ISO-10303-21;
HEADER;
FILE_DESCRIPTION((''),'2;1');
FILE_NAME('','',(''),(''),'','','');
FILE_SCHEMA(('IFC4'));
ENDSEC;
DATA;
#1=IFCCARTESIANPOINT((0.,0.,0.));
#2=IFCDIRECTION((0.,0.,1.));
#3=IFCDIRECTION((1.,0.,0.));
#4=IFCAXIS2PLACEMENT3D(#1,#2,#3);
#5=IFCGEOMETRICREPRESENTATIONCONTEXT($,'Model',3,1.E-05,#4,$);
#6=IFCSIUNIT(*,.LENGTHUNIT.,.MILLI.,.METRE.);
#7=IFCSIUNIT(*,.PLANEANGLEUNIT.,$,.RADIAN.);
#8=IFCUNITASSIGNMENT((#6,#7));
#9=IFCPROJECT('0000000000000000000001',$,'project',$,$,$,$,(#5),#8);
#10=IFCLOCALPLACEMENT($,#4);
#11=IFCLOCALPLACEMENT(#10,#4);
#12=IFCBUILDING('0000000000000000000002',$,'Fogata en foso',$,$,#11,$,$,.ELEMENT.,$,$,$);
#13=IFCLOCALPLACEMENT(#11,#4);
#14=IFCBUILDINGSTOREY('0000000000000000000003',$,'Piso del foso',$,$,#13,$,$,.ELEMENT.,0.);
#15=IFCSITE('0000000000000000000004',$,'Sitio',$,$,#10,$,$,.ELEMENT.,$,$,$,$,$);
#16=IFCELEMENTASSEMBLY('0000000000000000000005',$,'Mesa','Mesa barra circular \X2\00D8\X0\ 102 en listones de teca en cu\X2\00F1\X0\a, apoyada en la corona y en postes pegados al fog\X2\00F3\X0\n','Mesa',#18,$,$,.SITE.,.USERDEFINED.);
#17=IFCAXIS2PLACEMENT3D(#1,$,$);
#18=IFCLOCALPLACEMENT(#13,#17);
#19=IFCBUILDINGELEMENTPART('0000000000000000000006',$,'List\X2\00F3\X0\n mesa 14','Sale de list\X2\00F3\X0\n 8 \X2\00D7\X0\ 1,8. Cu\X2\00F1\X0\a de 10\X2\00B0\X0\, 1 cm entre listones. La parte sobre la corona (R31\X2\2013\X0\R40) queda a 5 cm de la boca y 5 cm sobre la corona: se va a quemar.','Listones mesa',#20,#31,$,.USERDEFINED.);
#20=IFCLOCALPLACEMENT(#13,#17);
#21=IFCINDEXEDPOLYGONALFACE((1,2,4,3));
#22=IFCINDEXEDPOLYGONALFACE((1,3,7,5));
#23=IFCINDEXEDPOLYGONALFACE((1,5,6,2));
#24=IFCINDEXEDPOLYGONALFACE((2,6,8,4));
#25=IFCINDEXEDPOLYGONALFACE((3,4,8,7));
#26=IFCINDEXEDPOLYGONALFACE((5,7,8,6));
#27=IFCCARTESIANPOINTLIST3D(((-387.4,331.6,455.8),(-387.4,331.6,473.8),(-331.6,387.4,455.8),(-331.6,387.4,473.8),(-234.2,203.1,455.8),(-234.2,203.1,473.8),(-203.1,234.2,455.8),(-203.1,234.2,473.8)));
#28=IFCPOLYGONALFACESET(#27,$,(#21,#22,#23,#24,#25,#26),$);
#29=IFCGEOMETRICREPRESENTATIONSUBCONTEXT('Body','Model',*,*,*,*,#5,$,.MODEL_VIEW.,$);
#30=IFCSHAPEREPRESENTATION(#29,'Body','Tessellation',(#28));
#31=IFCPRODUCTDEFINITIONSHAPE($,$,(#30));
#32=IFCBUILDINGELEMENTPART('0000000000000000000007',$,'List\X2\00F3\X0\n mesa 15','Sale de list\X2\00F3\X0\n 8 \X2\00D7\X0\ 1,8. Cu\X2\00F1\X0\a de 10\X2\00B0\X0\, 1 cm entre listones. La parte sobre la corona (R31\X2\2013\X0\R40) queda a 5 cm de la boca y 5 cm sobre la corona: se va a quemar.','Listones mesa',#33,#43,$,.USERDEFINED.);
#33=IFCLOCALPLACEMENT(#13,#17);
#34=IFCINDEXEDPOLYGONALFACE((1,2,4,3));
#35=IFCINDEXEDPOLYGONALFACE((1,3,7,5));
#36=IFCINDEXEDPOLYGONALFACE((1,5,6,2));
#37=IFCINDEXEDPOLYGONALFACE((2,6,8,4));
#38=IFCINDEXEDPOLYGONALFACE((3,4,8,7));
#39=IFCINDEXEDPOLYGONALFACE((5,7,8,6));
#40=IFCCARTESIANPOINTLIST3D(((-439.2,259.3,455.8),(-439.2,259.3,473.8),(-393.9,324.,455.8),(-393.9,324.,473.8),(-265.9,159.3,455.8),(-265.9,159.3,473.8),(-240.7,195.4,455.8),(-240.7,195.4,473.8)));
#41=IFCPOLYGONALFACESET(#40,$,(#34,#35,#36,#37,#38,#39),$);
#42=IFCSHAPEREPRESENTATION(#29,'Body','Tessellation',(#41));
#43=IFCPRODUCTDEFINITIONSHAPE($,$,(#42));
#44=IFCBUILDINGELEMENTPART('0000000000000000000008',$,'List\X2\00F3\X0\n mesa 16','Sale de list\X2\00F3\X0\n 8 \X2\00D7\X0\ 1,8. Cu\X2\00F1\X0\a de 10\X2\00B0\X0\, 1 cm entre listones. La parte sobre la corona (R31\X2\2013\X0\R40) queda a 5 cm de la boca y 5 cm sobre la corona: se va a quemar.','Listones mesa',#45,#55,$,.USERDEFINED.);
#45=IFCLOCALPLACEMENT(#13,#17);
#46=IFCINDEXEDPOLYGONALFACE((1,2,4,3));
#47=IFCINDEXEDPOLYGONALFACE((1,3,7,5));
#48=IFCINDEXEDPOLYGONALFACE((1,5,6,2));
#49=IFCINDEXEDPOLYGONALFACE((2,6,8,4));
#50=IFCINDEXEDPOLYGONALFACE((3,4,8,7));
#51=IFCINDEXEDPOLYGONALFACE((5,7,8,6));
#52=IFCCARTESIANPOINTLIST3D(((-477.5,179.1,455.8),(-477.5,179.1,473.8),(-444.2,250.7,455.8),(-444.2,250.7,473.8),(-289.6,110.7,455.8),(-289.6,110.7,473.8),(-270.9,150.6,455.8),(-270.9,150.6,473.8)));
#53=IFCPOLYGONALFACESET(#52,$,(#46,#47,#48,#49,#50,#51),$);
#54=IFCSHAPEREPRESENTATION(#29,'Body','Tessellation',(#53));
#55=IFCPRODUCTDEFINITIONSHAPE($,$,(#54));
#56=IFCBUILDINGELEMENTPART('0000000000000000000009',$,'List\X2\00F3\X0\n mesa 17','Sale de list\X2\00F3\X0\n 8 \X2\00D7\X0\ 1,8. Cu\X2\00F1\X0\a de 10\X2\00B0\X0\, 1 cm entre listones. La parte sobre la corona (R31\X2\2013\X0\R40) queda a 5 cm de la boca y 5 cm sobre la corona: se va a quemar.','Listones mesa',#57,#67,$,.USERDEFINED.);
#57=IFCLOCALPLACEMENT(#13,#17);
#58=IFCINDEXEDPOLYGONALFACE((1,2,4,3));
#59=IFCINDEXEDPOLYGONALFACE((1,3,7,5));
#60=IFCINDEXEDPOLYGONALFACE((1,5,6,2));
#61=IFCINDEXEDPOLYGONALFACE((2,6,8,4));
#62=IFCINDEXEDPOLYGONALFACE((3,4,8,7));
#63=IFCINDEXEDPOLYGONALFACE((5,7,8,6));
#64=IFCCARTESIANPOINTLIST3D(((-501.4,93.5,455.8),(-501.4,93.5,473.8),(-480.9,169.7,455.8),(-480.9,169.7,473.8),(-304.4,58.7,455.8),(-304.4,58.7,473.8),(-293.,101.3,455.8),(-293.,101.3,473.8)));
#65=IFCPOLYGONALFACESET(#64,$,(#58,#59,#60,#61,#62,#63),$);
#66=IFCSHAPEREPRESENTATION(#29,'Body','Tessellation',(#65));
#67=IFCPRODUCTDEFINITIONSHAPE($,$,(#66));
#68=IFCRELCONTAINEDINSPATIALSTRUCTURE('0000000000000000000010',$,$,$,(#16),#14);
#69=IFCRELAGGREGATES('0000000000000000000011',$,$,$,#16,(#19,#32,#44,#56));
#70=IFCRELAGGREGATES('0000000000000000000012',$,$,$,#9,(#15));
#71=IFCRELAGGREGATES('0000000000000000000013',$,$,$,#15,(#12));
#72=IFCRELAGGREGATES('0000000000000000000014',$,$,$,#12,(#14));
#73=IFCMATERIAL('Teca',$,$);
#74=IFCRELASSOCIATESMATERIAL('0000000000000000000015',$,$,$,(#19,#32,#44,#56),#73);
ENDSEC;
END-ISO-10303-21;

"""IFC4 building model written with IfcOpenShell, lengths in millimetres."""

from ifc_helpers import new_model, si_unit, frame, origin_with_axes, place, context, subcontext, project, spatial, polyline, outline, extrude, material, element, aggregate, save


model = new_model("IFC4")

# Units and contexts
model_context = context("Model", 3, precision=1e-05, world=origin_with_axes())
body_context = subcontext(model_context, "Body", "Model", "MODEL_VIEW")
ifc_project = project(units=[si_unit("LENGTHUNIT", "METRE", prefix="MILLI"), si_unit("PLANEANGLEUNIT", "RADIAN")], contexts=[model_context])

# Site, building, storey
site_placement = place(None, origin_with_axes())
site = spatial("IfcSite", under=ifc_project, at=site_placement, Name="Sitio", CompositionType="ELEMENT")
building_placement = place(site_placement, origin_with_axes())
building = spatial("IfcBuilding", under=site, at=building_placement, Name="Fogata en foso", CompositionType="ELEMENT")
storey_placement = place(building_placement, origin_with_axes())
storey = spatial("IfcBuildingStorey", under=building, at=storey_placement, Name="Piso del foso", CompositionType="ELEMENT", Elevation=0.0)

# Shared definitions
ifc_material_1 = material(Name="Teca")

# Element assembly, building element parts
assembly_1_placement = place(storey_placement, origin_with_axes())
assembly_1 = element("IfcElementAssembly", 1, at=assembly_1_placement, inside=storey, Name="Mesa", Description="Mesa barra circular Ø 102 en listones de teca en cuña, apoyada en la corona y en postes pegados al fogón", ObjectType="Mesa", AssemblyPlace="SITE", PredefinedType="USERDEFINED")
building_element_part_1_placement = place(storey_placement, frame((0.0, 0.0, 455.8), z_axis=(0.0, 0.0, 1.0), x_axis=(1.0, 0.0, 0.0)))
building_element_part_1 = element("IfcBuildingElementPart", 2, at=building_element_part_1_placement, material=ifc_material_1, Name="Listón mesa 14", Description="Sale de listón 8 × 1,8. Cuña de 10°, 1 cm entre listones. La parte sobre la corona (R31–R40) queda a 5 cm de la boca y 5 cm sobre la corona: se va a quemar.", ObjectType="Listones mesa", PredefinedType="USERDEFINED", context=body_context, shape_type="SweptSolid", body=[
    extrude(outline(polyline([(-203.1, 234.2), (-331.6, 387.4), (-387.4, 331.6), (-234.2, 203.1), (-203.1, 234.2)])), origin_with_axes(), (0.0, 0.0, 1.0), 18.0),
])
building_element_part_2_placement = place(storey_placement, frame((0.0, 0.0, 455.8), z_axis=(0.0, 0.0, 1.0), x_axis=(1.0, 0.0, 0.0)))
building_element_part_2 = element("IfcBuildingElementPart", 3, at=building_element_part_2_placement, material=ifc_material_1, Name="Listón mesa 15", Description="Sale de listón 8 × 1,8. Cuña de 10°, 1 cm entre listones. La parte sobre la corona (R31–R40) queda a 5 cm de la boca y 5 cm sobre la corona: se va a quemar.", ObjectType="Listones mesa", PredefinedType="USERDEFINED", context=body_context, shape_type="SweptSolid", body=[
    extrude(outline(polyline([(-240.7, 195.4), (-393.9, 324.0), (-439.2, 259.3), (-265.9, 159.3), (-240.7, 195.4)])), origin_with_axes(), (0.0, 0.0, 1.0), 18.0),
])
building_element_part_3_placement = place(storey_placement, frame((0.0, 0.0, 455.8), z_axis=(0.0, 0.0, 1.0), x_axis=(1.0, 0.0, 0.0)))
building_element_part_3 = element("IfcBuildingElementPart", 4, at=building_element_part_3_placement, material=ifc_material_1, Name="Listón mesa 16", Description="Sale de listón 8 × 1,8. Cuña de 10°, 1 cm entre listones. La parte sobre la corona (R31–R40) queda a 5 cm de la boca y 5 cm sobre la corona: se va a quemar.", ObjectType="Listones mesa", PredefinedType="USERDEFINED", context=body_context, shape_type="SweptSolid", body=[
    extrude(outline(polyline([(-270.9, 150.7), (-444.2, 250.7), (-477.5, 179.1), (-289.6, 110.7), (-270.9, 150.7)])), origin_with_axes(), (0.0, 0.0, 1.0), 18.0),
])
building_element_part_4_placement = place(storey_placement, frame((0.0, 0.0, 455.8), z_axis=(0.0, 0.0, 1.0), x_axis=(1.0, 0.0, 0.0)))
building_element_part_4 = element("IfcBuildingElementPart", 5, at=building_element_part_4_placement, material=ifc_material_1, Name="Listón mesa 17", Description="Sale de listón 8 × 1,8. Cuña de 10°, 1 cm entre listones. La parte sobre la corona (R31–R40) queda a 5 cm de la boca y 5 cm sobre la corona: se va a quemar.", ObjectType="Listones mesa", PredefinedType="USERDEFINED", context=body_context, shape_type="SweptSolid", body=[
    extrude(outline(polyline([(-293.0, 101.3), (-480.9, 169.7), (-501.4, 93.5), (-304.4, 58.7), (-293.0, 101.3)])), origin_with_axes(), (0.0, 0.0, 1.0), 18.0),
])
aggregate(assembly_1, [building_element_part_1, building_element_part_2, building_element_part_3, building_element_part_4])

save(model, "model.ifc")
